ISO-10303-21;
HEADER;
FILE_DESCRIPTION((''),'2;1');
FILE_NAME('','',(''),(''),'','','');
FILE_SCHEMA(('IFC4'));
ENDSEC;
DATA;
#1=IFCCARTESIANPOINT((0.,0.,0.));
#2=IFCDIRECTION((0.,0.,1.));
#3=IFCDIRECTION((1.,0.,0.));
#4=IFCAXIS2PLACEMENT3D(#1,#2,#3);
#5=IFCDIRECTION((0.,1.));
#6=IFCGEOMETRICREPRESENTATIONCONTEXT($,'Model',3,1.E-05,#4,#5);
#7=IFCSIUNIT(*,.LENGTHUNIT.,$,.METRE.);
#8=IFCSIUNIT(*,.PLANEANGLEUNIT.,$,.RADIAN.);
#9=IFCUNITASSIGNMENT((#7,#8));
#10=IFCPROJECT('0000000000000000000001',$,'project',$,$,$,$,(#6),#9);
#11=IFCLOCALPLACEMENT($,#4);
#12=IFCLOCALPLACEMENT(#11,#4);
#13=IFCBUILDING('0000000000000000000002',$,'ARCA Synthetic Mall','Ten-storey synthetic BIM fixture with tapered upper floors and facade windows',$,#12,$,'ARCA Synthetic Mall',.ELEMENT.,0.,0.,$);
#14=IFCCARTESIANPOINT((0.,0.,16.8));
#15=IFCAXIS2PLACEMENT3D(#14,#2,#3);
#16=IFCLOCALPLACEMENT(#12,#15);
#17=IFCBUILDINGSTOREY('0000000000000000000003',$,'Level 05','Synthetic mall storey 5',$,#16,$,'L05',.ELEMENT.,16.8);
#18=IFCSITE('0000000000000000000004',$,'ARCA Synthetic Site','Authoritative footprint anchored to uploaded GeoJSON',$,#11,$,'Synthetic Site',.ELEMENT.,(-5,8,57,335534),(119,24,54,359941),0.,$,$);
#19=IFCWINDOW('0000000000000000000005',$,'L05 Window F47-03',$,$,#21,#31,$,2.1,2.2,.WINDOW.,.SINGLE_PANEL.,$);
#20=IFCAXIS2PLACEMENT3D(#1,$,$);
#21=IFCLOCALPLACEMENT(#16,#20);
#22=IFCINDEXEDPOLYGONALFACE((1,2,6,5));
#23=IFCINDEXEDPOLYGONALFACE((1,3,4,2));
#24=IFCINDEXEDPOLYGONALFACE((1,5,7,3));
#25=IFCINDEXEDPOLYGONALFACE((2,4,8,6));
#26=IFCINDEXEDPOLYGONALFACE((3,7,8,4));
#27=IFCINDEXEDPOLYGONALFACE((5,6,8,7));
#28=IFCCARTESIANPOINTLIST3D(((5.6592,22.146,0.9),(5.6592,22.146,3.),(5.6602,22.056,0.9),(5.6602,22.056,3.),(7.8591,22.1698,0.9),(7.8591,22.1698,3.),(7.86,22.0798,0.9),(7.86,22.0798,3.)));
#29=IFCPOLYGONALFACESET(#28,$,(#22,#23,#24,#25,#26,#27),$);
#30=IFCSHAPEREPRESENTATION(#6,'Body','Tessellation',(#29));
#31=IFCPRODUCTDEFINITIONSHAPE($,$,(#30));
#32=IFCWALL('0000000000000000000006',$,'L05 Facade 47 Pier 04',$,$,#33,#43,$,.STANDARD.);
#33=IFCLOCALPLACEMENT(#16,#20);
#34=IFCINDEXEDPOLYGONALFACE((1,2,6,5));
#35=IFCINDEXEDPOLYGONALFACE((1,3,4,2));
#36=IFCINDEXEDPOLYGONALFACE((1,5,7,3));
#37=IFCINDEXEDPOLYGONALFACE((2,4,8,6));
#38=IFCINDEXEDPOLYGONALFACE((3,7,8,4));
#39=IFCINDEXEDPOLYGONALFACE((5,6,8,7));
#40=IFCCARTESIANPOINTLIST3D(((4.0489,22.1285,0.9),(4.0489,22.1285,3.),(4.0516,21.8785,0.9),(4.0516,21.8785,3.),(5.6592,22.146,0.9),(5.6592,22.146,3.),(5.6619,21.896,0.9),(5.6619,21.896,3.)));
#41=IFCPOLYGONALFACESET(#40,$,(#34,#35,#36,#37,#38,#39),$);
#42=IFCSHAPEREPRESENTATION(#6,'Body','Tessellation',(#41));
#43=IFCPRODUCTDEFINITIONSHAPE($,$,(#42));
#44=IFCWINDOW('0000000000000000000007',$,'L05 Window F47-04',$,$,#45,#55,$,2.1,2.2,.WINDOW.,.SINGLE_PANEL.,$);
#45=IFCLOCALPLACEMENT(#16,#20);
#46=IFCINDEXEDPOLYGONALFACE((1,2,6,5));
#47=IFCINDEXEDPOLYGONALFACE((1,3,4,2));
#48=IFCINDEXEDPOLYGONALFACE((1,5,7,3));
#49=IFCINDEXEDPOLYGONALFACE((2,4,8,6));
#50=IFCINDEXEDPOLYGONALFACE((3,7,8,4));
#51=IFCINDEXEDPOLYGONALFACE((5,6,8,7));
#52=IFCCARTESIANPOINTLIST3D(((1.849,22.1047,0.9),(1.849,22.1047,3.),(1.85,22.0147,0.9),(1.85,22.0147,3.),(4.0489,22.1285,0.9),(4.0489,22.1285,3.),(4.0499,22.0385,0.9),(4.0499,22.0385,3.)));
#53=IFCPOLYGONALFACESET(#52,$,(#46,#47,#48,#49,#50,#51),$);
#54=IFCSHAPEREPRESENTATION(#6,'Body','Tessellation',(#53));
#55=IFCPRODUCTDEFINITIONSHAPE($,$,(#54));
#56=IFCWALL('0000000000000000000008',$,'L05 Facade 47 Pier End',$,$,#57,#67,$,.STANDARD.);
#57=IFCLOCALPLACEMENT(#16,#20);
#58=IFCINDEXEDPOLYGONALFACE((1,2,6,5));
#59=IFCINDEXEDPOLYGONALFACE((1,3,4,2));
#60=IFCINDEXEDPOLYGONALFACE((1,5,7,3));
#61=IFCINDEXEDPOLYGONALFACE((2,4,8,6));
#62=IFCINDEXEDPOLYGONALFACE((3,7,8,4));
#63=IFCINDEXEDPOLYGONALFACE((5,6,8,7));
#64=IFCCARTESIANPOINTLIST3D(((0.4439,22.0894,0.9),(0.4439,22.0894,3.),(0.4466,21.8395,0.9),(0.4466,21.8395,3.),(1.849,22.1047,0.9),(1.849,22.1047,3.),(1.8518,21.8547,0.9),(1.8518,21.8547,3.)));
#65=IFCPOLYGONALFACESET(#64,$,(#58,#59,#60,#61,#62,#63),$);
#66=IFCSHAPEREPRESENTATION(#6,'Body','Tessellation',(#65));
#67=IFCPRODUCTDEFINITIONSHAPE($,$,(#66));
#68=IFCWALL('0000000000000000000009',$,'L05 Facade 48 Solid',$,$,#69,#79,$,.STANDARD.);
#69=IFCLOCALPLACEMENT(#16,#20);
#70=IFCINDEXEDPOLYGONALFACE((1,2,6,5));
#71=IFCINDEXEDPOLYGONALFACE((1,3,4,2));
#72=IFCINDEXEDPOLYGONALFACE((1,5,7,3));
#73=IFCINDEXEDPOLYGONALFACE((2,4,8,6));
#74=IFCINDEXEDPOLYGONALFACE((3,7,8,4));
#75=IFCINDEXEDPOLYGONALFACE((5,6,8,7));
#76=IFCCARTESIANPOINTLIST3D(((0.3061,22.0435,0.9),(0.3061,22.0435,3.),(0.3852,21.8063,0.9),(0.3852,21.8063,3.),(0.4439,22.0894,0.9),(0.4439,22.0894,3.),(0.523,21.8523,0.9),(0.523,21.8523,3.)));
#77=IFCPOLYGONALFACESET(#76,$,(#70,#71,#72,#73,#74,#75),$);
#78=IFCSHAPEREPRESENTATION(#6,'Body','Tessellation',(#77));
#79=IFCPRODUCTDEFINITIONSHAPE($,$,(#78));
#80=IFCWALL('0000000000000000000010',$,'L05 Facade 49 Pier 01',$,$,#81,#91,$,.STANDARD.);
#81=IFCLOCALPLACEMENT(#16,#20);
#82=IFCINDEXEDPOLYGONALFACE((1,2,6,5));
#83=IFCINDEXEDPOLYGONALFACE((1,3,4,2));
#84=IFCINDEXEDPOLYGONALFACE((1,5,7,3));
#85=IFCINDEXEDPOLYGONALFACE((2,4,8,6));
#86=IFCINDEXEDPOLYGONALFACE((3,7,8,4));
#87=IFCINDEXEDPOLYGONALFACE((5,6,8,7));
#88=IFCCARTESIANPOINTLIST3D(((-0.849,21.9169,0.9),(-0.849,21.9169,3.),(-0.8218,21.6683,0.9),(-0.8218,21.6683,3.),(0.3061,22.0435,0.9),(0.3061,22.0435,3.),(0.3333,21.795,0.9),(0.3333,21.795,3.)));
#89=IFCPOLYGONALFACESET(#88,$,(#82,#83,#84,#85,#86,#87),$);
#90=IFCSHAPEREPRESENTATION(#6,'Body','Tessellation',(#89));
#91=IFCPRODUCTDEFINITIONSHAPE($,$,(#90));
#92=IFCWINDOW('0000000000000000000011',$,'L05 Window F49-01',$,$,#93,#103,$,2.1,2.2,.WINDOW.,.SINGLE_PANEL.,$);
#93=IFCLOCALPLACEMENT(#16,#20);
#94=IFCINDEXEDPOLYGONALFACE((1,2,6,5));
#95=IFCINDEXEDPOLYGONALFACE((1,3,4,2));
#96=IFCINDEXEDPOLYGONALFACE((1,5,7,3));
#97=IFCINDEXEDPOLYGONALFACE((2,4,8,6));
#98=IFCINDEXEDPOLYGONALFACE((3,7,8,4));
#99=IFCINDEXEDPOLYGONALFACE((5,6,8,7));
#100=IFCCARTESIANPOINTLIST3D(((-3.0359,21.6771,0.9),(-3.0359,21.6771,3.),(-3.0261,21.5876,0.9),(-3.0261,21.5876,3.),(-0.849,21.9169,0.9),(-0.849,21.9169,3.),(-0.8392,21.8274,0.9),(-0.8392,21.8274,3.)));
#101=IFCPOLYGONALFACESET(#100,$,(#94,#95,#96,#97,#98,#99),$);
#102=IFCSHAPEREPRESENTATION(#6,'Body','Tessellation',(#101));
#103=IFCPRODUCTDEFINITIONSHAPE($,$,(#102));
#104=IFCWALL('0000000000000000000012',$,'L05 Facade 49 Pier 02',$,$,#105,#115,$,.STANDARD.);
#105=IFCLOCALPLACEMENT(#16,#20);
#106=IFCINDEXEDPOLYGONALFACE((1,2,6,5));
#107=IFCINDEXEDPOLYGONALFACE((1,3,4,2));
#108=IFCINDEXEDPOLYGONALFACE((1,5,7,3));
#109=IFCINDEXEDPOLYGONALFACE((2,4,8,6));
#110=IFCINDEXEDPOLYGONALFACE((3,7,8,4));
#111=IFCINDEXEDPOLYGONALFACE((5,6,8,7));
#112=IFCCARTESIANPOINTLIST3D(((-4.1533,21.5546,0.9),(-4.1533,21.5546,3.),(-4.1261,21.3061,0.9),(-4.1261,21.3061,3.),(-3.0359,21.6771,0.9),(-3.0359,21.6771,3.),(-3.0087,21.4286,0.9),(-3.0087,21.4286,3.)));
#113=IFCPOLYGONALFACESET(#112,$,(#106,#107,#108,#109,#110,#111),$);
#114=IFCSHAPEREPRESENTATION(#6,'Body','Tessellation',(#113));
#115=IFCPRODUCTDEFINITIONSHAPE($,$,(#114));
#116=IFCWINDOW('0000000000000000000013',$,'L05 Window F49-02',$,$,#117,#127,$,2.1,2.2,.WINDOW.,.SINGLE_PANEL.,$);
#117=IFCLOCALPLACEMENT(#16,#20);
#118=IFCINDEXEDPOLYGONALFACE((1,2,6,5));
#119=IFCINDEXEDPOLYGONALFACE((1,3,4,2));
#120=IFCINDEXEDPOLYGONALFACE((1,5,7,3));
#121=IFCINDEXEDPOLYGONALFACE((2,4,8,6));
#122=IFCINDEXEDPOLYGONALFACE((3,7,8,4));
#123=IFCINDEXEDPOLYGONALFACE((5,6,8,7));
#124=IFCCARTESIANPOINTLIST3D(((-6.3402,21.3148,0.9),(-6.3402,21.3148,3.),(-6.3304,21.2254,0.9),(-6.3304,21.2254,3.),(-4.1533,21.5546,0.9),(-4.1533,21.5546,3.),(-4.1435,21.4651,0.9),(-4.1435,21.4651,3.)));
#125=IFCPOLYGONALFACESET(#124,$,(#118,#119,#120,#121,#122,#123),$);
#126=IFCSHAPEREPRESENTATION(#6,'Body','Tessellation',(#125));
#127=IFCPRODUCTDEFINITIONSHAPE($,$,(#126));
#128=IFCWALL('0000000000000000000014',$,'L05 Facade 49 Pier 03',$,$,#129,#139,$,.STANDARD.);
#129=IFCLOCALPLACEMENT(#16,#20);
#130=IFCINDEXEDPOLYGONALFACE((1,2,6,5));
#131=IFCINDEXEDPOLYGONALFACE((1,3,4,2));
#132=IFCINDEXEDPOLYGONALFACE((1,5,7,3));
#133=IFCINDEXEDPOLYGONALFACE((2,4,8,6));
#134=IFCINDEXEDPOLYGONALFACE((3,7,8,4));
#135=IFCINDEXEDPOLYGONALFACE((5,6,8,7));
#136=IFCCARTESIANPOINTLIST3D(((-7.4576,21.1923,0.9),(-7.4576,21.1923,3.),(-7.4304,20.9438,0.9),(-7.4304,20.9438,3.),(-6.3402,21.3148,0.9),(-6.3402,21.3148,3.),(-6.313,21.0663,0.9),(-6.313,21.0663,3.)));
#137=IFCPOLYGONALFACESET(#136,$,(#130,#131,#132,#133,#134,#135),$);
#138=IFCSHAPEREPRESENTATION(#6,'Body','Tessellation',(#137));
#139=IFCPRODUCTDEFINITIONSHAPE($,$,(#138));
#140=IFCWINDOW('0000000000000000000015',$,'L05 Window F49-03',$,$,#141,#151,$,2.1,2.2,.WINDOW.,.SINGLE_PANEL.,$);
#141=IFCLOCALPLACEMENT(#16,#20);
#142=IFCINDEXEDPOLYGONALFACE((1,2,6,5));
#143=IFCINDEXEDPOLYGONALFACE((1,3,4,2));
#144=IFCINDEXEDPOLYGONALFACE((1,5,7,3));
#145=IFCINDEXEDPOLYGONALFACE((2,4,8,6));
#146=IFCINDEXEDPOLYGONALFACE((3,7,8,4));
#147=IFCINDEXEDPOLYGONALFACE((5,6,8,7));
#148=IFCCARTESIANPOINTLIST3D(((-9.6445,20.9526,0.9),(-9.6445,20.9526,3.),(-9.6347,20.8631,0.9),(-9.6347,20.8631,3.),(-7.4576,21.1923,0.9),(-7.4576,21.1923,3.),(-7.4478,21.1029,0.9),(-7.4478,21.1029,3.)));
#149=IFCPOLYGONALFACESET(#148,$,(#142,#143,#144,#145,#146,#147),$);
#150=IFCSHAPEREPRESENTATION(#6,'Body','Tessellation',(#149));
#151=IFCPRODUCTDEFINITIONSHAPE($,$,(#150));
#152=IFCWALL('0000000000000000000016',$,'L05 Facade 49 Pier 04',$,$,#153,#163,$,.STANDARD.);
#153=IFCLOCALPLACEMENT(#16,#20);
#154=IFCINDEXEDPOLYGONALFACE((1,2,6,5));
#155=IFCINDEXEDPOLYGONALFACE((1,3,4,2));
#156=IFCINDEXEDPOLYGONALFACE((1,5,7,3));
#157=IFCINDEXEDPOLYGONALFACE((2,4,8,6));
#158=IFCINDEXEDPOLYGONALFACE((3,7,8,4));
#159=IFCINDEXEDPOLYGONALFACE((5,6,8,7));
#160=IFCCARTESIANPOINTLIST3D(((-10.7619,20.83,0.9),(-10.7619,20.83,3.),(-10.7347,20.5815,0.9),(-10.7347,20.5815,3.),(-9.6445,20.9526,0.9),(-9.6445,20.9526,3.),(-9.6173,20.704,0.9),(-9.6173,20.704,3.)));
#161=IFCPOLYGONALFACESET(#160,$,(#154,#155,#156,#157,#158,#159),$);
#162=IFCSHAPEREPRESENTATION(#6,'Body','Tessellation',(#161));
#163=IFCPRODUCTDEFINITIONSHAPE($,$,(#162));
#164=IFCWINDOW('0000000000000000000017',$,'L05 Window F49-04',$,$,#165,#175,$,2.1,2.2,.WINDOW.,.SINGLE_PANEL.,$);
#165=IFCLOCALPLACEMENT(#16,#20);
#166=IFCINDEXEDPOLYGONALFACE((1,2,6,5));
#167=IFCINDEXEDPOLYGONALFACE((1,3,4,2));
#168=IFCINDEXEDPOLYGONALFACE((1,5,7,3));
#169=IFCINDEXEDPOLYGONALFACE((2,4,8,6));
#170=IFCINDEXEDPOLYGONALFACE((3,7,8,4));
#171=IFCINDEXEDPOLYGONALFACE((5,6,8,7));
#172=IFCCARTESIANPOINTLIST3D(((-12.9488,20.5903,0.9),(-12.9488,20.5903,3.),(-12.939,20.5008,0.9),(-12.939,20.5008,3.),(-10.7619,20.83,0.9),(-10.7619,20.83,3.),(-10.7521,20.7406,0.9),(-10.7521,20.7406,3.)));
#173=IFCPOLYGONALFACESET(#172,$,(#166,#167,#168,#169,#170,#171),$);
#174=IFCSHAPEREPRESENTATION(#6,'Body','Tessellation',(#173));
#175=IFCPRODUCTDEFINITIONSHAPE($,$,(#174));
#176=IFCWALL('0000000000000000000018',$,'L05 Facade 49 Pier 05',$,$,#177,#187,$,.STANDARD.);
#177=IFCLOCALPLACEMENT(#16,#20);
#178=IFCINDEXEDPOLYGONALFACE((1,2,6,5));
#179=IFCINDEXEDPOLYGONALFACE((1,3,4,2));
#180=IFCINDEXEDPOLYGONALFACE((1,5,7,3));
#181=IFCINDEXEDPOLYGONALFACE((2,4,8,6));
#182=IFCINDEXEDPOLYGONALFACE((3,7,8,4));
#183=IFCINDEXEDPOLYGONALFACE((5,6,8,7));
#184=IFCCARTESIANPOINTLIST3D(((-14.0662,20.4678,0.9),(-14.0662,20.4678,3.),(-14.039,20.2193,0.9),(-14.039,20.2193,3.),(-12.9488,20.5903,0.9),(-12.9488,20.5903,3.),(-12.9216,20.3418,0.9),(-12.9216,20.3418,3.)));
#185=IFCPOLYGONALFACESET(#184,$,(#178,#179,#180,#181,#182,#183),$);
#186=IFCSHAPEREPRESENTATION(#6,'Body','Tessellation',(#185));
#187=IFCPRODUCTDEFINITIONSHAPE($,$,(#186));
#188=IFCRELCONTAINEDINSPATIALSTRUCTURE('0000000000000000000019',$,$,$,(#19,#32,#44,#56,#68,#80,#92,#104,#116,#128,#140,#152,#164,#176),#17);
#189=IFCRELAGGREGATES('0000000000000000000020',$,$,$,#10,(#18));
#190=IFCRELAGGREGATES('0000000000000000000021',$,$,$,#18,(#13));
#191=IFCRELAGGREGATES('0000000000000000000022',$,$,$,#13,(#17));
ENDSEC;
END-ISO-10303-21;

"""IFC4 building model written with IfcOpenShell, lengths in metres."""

from ifc_helpers import new_model, si_unit, direction, frame, origin_with_axes, place, context, project, spatial, polyline, outline, extrude, element, save


model = new_model("IFC4")

# Units and contexts
model_context = context("Model", 3, precision=1e-05, world=origin_with_axes(), true_north=direction((0.0, 1.0)))
ifc_project = project(units=[si_unit("LENGTHUNIT", "METRE"), si_unit("PLANEANGLEUNIT", "RADIAN")], contexts=[model_context])

# Site, building, storey
site_placement = place(None, origin_with_axes())
site = spatial("IfcSite", under=ifc_project, at=site_placement, Name="ARCA Synthetic Site", Description="Authoritative footprint anchored to uploaded GeoJSON", LongName="Synthetic Site", CompositionType="ELEMENT", RefLatitude=(-5, 8, 57, 335534), RefLongitude=(119, 24, 54, 359941), RefElevation=0.0)
building_placement = place(site_placement, origin_with_axes())
building = spatial("IfcBuilding", under=site, at=building_placement, Name="ARCA Synthetic Mall", Description="Ten-storey synthetic BIM fixture with tapered upper floors and facade windows", LongName="ARCA Synthetic Mall", CompositionType="ELEMENT", ElevationOfRefHeight=0.0, ElevationOfTerrain=0.0)
storey_placement = place(building_placement, frame((0.0, 0.0, 16.8), z_axis=(0.0, 0.0, 1.0), x_axis=(1.0, 0.0, 0.0)))
storey = spatial("IfcBuildingStorey", under=building, at=storey_placement, Name="Level 05", Description="Synthetic mall storey 5", LongName="L05", CompositionType="ELEMENT", Elevation=16.8)

# Window
window_1_placement = place(storey_placement, frame((0.0, 0.0, 0.9), z_axis=(0.0, 0.0, 1.0), x_axis=(1.0, 0.0, 0.0)))
element("IfcWindow", 1, at=window_1_placement, inside=storey, Name="L05 Window F47-03", OverallHeight=2.1, OverallWidth=2.2, PartitioningType="SINGLE_PANEL", PredefinedType="WINDOW", context=model_context, shape_type="SweptSolid", body=[
    extrude(outline(polyline([(7.8591, 22.1698), (5.6592, 22.146), (5.6602, 22.056), (7.86, 22.0798), (7.8591, 22.1698)])), origin_with_axes(), (0.0, 0.0, 1.0), 2.1),
])

# Wall
wall_1_placement = place(storey_placement, frame((0.0, 0.0, 0.9), z_axis=(0.0, 0.0, 1.0), x_axis=(1.0, 0.0, 0.0)))
element("IfcWall", 2, at=wall_1_placement, inside=storey, Name="L05 Facade 47 Pier 04", PredefinedType="STANDARD", context=model_context, shape_type="SweptSolid", body=[
    extrude(outline(polyline([(5.6592, 22.146), (4.0489, 22.1285), (4.0516, 21.8785), (5.6619, 21.896), (5.6592, 22.146)])), origin_with_axes(), (0.0, 0.0, 1.0), 2.1),
])

# Window
window_2_placement = place(storey_placement, frame((0.0, 0.0, 0.9), z_axis=(0.0, 0.0, 1.0), x_axis=(1.0, 0.0, 0.0)))
element("IfcWindow", 3, at=window_2_placement, inside=storey, Name="L05 Window F47-04", OverallHeight=2.1, OverallWidth=2.2, PartitioningType="SINGLE_PANEL", PredefinedType="WINDOW", context=model_context, shape_type="SweptSolid", body=[
    extrude(outline(polyline([(4.0489, 22.1285), (1.849, 22.1047), (1.85, 22.0147), (4.0499, 22.0385), (4.0489, 22.1285)])), origin_with_axes(), (0.0, 0.0, 1.0), 2.1),
])

# Walls
wall_2_placement = place(storey_placement, frame((0.0, 0.0, 0.9), z_axis=(0.0, 0.0, 1.0), x_axis=(1.0, 0.0, 0.0)))
element("IfcWall", 4, at=wall_2_placement, inside=storey, Name="L05 Facade 47 Pier End", PredefinedType="STANDARD", context=model_context, shape_type="SweptSolid", body=[
    extrude(outline(polyline([(1.849, 22.1047), (0.4439, 22.0894), (0.4466, 21.8395), (1.8518, 21.8547), (1.849, 22.1047)])), origin_with_axes(), (0.0, 0.0, 1.0), 2.1),
])
wall_3_placement = place(storey_placement, frame((0.0, 0.0, 0.9), z_axis=(0.0, 0.0, 1.0), x_axis=(1.0, 0.0, 0.0)))
element("IfcWall", 5, at=wall_3_placement, inside=storey, Name="L05 Facade 48 Solid", PredefinedType="STANDARD", context=model_context, shape_type="SweptSolid", body=[
    extrude(outline(polyline([(0.4439, 22.0894), (0.3061, 22.0435), (0.3852, 21.8063), (0.523, 21.8523), (0.4439, 22.0894)])), origin_with_axes(), (0.0, 0.0, 1.0), 2.1),
])
wall_4_placement = place(storey_placement, frame((0.0, 0.0, 0.9), z_axis=(0.0, 0.0, 1.0), x_axis=(1.0, 0.0, 0.0)))
element("IfcWall", 6, at=wall_4_placement, inside=storey, Name="L05 Facade 49 Pier 01", PredefinedType="STANDARD", context=model_context, shape_type="SweptSolid", body=[
    extrude(outline(polyline([(0.3061, 22.0435), (-0.849, 21.9169), (-0.8218, 21.6683), (0.3333, 21.795), (0.3061, 22.0435)])), origin_with_axes(), (0.0, 0.0, 1.0), 2.1),
])

# Window
window_3_placement = place(storey_placement, frame((0.0, 0.0, 0.9), z_axis=(0.0, 0.0, 1.0), x_axis=(1.0, 0.0, 0.0)))
element("IfcWindow", 7, at=window_3_placement, inside=storey, Name="L05 Window F49-01", OverallHeight=2.1, OverallWidth=2.2, PartitioningType="SINGLE_PANEL", PredefinedType="WINDOW", context=model_context, shape_type="SweptSolid", body=[
    extrude(outline(polyline([(-0.849, 21.9169), (-3.0359, 21.6771), (-3.0261, 21.5876), (-0.8392, 21.8274), (-0.849, 21.9169)])), origin_with_axes(), (0.0, 0.0, 1.0), 2.1),
])

# Wall
wall_5_placement = place(storey_placement, frame((0.0, 0.0, 0.9), z_axis=(0.0, 0.0, 1.0), x_axis=(1.0, 0.0, 0.0)))
element("IfcWall", 8, at=wall_5_placement, inside=storey, Name="L05 Facade 49 Pier 02", PredefinedType="STANDARD", context=model_context, shape_type="SweptSolid", body=[
    extrude(outline(polyline([(-3.0359, 21.6771), (-4.1533, 21.5546), (-4.1261, 21.3061), (-3.0087, 21.4286), (-3.0359, 21.6771)])), origin_with_axes(), (0.0, 0.0, 1.0), 2.1),
])

# Window
window_4_placement = place(storey_placement, frame((0.0, 0.0, 0.9), z_axis=(0.0, 0.0, 1.0), x_axis=(1.0, 0.0, 0.0)))
element("IfcWindow", 9, at=window_4_placement, inside=storey, Name="L05 Window F49-02", OverallHeight=2.1, OverallWidth=2.2, PartitioningType="SINGLE_PANEL", PredefinedType="WINDOW", context=model_context, shape_type="SweptSolid", body=[
    extrude(outline(polyline([(-4.1533, 21.5546), (-6.3402, 21.3148), (-6.3304, 21.2254), (-4.1435, 21.4651), (-4.1533, 21.5546)])), origin_with_axes(), (0.0, 0.0, 1.0), 2.1),
])

# Wall
wall_6_placement = place(storey_placement, frame((0.0, 0.0, 0.9), z_axis=(0.0, 0.0, 1.0), x_axis=(1.0, 0.0, 0.0)))
element("IfcWall", 10, at=wall_6_placement, inside=storey, Name="L05 Facade 49 Pier 03", PredefinedType="STANDARD", context=model_context, shape_type="SweptSolid", body=[
    extrude(outline(polyline([(-6.3402, 21.3148), (-7.4576, 21.1923), (-7.4304, 20.9438), (-6.313, 21.0663), (-6.3402, 21.3148)])), origin_with_axes(), (0.0, 0.0, 1.0), 2.1),
])

# Window
window_5_placement = place(storey_placement, frame((0.0, 0.0, 0.9), z_axis=(0.0, 0.0, 1.0), x_axis=(1.0, 0.0, 0.0)))
element("IfcWindow", 11, at=window_5_placement, inside=storey, Name="L05 Window F49-03", OverallHeight=2.1, OverallWidth=2.2, PartitioningType="SINGLE_PANEL", PredefinedType="WINDOW", context=model_context, shape_type="SweptSolid", body=[
    extrude(outline(polyline([(-7.4576, 21.1923), (-9.6445, 20.9526), (-9.6347, 20.8631), (-7.4478, 21.1029), (-7.4576, 21.1923)])), origin_with_axes(), (0.0, 0.0, 1.0), 2.1),
])

# Wall
wall_7_placement = place(storey_placement, frame((0.0, 0.0, 0.9), z_axis=(0.0, 0.0, 1.0), x_axis=(1.0, 0.0, 0.0)))
element("IfcWall", 12, at=wall_7_placement, inside=storey, Name="L05 Facade 49 Pier 04", PredefinedType="STANDARD", context=model_context, shape_type="SweptSolid", body=[
    extrude(outline(polyline([(-9.6445, 20.9526), (-10.7619, 20.83), (-10.7347, 20.5815), (-9.6173, 20.704), (-9.6445, 20.9526)])), origin_with_axes(), (0.0, 0.0, 1.0), 2.1),
])

# Window
window_6_placement = place(storey_placement, frame((0.0, 0.0, 0.9), z_axis=(0.0, 0.0, 1.0), x_axis=(1.0, 0.0, 0.0)))
element("IfcWindow", 13, at=window_6_placement, inside=storey, Name="L05 Window F49-04", OverallHeight=2.1, OverallWidth=2.2, PartitioningType="SINGLE_PANEL", PredefinedType="WINDOW", context=model_context, shape_type="SweptSolid", body=[
    extrude(outline(polyline([(-10.7619, 20.83), (-12.9488, 20.5903), (-12.939, 20.5008), (-10.7521, 20.7406), (-10.7619, 20.83)])), origin_with_axes(), (0.0, 0.0, 1.0), 2.1),
])

# Wall
wall_8_placement = place(storey_placement, frame((0.0, 0.0, 0.9), z_axis=(0.0, 0.0, 1.0), x_axis=(1.0, 0.0, 0.0)))
element("IfcWall", 14, at=wall_8_placement, inside=storey, Name="L05 Facade 49 Pier 05", PredefinedType="STANDARD", context=model_context, shape_type="SweptSolid", body=[
    extrude(outline(polyline([(-12.9488, 20.5903), (-14.0662, 20.4678), (-14.039, 20.2193), (-12.9216, 20.3418), (-12.9488, 20.5903)])), origin_with_axes(), (0.0, 0.0, 1.0), 2.1),
])

save(model, "model.ifc")
